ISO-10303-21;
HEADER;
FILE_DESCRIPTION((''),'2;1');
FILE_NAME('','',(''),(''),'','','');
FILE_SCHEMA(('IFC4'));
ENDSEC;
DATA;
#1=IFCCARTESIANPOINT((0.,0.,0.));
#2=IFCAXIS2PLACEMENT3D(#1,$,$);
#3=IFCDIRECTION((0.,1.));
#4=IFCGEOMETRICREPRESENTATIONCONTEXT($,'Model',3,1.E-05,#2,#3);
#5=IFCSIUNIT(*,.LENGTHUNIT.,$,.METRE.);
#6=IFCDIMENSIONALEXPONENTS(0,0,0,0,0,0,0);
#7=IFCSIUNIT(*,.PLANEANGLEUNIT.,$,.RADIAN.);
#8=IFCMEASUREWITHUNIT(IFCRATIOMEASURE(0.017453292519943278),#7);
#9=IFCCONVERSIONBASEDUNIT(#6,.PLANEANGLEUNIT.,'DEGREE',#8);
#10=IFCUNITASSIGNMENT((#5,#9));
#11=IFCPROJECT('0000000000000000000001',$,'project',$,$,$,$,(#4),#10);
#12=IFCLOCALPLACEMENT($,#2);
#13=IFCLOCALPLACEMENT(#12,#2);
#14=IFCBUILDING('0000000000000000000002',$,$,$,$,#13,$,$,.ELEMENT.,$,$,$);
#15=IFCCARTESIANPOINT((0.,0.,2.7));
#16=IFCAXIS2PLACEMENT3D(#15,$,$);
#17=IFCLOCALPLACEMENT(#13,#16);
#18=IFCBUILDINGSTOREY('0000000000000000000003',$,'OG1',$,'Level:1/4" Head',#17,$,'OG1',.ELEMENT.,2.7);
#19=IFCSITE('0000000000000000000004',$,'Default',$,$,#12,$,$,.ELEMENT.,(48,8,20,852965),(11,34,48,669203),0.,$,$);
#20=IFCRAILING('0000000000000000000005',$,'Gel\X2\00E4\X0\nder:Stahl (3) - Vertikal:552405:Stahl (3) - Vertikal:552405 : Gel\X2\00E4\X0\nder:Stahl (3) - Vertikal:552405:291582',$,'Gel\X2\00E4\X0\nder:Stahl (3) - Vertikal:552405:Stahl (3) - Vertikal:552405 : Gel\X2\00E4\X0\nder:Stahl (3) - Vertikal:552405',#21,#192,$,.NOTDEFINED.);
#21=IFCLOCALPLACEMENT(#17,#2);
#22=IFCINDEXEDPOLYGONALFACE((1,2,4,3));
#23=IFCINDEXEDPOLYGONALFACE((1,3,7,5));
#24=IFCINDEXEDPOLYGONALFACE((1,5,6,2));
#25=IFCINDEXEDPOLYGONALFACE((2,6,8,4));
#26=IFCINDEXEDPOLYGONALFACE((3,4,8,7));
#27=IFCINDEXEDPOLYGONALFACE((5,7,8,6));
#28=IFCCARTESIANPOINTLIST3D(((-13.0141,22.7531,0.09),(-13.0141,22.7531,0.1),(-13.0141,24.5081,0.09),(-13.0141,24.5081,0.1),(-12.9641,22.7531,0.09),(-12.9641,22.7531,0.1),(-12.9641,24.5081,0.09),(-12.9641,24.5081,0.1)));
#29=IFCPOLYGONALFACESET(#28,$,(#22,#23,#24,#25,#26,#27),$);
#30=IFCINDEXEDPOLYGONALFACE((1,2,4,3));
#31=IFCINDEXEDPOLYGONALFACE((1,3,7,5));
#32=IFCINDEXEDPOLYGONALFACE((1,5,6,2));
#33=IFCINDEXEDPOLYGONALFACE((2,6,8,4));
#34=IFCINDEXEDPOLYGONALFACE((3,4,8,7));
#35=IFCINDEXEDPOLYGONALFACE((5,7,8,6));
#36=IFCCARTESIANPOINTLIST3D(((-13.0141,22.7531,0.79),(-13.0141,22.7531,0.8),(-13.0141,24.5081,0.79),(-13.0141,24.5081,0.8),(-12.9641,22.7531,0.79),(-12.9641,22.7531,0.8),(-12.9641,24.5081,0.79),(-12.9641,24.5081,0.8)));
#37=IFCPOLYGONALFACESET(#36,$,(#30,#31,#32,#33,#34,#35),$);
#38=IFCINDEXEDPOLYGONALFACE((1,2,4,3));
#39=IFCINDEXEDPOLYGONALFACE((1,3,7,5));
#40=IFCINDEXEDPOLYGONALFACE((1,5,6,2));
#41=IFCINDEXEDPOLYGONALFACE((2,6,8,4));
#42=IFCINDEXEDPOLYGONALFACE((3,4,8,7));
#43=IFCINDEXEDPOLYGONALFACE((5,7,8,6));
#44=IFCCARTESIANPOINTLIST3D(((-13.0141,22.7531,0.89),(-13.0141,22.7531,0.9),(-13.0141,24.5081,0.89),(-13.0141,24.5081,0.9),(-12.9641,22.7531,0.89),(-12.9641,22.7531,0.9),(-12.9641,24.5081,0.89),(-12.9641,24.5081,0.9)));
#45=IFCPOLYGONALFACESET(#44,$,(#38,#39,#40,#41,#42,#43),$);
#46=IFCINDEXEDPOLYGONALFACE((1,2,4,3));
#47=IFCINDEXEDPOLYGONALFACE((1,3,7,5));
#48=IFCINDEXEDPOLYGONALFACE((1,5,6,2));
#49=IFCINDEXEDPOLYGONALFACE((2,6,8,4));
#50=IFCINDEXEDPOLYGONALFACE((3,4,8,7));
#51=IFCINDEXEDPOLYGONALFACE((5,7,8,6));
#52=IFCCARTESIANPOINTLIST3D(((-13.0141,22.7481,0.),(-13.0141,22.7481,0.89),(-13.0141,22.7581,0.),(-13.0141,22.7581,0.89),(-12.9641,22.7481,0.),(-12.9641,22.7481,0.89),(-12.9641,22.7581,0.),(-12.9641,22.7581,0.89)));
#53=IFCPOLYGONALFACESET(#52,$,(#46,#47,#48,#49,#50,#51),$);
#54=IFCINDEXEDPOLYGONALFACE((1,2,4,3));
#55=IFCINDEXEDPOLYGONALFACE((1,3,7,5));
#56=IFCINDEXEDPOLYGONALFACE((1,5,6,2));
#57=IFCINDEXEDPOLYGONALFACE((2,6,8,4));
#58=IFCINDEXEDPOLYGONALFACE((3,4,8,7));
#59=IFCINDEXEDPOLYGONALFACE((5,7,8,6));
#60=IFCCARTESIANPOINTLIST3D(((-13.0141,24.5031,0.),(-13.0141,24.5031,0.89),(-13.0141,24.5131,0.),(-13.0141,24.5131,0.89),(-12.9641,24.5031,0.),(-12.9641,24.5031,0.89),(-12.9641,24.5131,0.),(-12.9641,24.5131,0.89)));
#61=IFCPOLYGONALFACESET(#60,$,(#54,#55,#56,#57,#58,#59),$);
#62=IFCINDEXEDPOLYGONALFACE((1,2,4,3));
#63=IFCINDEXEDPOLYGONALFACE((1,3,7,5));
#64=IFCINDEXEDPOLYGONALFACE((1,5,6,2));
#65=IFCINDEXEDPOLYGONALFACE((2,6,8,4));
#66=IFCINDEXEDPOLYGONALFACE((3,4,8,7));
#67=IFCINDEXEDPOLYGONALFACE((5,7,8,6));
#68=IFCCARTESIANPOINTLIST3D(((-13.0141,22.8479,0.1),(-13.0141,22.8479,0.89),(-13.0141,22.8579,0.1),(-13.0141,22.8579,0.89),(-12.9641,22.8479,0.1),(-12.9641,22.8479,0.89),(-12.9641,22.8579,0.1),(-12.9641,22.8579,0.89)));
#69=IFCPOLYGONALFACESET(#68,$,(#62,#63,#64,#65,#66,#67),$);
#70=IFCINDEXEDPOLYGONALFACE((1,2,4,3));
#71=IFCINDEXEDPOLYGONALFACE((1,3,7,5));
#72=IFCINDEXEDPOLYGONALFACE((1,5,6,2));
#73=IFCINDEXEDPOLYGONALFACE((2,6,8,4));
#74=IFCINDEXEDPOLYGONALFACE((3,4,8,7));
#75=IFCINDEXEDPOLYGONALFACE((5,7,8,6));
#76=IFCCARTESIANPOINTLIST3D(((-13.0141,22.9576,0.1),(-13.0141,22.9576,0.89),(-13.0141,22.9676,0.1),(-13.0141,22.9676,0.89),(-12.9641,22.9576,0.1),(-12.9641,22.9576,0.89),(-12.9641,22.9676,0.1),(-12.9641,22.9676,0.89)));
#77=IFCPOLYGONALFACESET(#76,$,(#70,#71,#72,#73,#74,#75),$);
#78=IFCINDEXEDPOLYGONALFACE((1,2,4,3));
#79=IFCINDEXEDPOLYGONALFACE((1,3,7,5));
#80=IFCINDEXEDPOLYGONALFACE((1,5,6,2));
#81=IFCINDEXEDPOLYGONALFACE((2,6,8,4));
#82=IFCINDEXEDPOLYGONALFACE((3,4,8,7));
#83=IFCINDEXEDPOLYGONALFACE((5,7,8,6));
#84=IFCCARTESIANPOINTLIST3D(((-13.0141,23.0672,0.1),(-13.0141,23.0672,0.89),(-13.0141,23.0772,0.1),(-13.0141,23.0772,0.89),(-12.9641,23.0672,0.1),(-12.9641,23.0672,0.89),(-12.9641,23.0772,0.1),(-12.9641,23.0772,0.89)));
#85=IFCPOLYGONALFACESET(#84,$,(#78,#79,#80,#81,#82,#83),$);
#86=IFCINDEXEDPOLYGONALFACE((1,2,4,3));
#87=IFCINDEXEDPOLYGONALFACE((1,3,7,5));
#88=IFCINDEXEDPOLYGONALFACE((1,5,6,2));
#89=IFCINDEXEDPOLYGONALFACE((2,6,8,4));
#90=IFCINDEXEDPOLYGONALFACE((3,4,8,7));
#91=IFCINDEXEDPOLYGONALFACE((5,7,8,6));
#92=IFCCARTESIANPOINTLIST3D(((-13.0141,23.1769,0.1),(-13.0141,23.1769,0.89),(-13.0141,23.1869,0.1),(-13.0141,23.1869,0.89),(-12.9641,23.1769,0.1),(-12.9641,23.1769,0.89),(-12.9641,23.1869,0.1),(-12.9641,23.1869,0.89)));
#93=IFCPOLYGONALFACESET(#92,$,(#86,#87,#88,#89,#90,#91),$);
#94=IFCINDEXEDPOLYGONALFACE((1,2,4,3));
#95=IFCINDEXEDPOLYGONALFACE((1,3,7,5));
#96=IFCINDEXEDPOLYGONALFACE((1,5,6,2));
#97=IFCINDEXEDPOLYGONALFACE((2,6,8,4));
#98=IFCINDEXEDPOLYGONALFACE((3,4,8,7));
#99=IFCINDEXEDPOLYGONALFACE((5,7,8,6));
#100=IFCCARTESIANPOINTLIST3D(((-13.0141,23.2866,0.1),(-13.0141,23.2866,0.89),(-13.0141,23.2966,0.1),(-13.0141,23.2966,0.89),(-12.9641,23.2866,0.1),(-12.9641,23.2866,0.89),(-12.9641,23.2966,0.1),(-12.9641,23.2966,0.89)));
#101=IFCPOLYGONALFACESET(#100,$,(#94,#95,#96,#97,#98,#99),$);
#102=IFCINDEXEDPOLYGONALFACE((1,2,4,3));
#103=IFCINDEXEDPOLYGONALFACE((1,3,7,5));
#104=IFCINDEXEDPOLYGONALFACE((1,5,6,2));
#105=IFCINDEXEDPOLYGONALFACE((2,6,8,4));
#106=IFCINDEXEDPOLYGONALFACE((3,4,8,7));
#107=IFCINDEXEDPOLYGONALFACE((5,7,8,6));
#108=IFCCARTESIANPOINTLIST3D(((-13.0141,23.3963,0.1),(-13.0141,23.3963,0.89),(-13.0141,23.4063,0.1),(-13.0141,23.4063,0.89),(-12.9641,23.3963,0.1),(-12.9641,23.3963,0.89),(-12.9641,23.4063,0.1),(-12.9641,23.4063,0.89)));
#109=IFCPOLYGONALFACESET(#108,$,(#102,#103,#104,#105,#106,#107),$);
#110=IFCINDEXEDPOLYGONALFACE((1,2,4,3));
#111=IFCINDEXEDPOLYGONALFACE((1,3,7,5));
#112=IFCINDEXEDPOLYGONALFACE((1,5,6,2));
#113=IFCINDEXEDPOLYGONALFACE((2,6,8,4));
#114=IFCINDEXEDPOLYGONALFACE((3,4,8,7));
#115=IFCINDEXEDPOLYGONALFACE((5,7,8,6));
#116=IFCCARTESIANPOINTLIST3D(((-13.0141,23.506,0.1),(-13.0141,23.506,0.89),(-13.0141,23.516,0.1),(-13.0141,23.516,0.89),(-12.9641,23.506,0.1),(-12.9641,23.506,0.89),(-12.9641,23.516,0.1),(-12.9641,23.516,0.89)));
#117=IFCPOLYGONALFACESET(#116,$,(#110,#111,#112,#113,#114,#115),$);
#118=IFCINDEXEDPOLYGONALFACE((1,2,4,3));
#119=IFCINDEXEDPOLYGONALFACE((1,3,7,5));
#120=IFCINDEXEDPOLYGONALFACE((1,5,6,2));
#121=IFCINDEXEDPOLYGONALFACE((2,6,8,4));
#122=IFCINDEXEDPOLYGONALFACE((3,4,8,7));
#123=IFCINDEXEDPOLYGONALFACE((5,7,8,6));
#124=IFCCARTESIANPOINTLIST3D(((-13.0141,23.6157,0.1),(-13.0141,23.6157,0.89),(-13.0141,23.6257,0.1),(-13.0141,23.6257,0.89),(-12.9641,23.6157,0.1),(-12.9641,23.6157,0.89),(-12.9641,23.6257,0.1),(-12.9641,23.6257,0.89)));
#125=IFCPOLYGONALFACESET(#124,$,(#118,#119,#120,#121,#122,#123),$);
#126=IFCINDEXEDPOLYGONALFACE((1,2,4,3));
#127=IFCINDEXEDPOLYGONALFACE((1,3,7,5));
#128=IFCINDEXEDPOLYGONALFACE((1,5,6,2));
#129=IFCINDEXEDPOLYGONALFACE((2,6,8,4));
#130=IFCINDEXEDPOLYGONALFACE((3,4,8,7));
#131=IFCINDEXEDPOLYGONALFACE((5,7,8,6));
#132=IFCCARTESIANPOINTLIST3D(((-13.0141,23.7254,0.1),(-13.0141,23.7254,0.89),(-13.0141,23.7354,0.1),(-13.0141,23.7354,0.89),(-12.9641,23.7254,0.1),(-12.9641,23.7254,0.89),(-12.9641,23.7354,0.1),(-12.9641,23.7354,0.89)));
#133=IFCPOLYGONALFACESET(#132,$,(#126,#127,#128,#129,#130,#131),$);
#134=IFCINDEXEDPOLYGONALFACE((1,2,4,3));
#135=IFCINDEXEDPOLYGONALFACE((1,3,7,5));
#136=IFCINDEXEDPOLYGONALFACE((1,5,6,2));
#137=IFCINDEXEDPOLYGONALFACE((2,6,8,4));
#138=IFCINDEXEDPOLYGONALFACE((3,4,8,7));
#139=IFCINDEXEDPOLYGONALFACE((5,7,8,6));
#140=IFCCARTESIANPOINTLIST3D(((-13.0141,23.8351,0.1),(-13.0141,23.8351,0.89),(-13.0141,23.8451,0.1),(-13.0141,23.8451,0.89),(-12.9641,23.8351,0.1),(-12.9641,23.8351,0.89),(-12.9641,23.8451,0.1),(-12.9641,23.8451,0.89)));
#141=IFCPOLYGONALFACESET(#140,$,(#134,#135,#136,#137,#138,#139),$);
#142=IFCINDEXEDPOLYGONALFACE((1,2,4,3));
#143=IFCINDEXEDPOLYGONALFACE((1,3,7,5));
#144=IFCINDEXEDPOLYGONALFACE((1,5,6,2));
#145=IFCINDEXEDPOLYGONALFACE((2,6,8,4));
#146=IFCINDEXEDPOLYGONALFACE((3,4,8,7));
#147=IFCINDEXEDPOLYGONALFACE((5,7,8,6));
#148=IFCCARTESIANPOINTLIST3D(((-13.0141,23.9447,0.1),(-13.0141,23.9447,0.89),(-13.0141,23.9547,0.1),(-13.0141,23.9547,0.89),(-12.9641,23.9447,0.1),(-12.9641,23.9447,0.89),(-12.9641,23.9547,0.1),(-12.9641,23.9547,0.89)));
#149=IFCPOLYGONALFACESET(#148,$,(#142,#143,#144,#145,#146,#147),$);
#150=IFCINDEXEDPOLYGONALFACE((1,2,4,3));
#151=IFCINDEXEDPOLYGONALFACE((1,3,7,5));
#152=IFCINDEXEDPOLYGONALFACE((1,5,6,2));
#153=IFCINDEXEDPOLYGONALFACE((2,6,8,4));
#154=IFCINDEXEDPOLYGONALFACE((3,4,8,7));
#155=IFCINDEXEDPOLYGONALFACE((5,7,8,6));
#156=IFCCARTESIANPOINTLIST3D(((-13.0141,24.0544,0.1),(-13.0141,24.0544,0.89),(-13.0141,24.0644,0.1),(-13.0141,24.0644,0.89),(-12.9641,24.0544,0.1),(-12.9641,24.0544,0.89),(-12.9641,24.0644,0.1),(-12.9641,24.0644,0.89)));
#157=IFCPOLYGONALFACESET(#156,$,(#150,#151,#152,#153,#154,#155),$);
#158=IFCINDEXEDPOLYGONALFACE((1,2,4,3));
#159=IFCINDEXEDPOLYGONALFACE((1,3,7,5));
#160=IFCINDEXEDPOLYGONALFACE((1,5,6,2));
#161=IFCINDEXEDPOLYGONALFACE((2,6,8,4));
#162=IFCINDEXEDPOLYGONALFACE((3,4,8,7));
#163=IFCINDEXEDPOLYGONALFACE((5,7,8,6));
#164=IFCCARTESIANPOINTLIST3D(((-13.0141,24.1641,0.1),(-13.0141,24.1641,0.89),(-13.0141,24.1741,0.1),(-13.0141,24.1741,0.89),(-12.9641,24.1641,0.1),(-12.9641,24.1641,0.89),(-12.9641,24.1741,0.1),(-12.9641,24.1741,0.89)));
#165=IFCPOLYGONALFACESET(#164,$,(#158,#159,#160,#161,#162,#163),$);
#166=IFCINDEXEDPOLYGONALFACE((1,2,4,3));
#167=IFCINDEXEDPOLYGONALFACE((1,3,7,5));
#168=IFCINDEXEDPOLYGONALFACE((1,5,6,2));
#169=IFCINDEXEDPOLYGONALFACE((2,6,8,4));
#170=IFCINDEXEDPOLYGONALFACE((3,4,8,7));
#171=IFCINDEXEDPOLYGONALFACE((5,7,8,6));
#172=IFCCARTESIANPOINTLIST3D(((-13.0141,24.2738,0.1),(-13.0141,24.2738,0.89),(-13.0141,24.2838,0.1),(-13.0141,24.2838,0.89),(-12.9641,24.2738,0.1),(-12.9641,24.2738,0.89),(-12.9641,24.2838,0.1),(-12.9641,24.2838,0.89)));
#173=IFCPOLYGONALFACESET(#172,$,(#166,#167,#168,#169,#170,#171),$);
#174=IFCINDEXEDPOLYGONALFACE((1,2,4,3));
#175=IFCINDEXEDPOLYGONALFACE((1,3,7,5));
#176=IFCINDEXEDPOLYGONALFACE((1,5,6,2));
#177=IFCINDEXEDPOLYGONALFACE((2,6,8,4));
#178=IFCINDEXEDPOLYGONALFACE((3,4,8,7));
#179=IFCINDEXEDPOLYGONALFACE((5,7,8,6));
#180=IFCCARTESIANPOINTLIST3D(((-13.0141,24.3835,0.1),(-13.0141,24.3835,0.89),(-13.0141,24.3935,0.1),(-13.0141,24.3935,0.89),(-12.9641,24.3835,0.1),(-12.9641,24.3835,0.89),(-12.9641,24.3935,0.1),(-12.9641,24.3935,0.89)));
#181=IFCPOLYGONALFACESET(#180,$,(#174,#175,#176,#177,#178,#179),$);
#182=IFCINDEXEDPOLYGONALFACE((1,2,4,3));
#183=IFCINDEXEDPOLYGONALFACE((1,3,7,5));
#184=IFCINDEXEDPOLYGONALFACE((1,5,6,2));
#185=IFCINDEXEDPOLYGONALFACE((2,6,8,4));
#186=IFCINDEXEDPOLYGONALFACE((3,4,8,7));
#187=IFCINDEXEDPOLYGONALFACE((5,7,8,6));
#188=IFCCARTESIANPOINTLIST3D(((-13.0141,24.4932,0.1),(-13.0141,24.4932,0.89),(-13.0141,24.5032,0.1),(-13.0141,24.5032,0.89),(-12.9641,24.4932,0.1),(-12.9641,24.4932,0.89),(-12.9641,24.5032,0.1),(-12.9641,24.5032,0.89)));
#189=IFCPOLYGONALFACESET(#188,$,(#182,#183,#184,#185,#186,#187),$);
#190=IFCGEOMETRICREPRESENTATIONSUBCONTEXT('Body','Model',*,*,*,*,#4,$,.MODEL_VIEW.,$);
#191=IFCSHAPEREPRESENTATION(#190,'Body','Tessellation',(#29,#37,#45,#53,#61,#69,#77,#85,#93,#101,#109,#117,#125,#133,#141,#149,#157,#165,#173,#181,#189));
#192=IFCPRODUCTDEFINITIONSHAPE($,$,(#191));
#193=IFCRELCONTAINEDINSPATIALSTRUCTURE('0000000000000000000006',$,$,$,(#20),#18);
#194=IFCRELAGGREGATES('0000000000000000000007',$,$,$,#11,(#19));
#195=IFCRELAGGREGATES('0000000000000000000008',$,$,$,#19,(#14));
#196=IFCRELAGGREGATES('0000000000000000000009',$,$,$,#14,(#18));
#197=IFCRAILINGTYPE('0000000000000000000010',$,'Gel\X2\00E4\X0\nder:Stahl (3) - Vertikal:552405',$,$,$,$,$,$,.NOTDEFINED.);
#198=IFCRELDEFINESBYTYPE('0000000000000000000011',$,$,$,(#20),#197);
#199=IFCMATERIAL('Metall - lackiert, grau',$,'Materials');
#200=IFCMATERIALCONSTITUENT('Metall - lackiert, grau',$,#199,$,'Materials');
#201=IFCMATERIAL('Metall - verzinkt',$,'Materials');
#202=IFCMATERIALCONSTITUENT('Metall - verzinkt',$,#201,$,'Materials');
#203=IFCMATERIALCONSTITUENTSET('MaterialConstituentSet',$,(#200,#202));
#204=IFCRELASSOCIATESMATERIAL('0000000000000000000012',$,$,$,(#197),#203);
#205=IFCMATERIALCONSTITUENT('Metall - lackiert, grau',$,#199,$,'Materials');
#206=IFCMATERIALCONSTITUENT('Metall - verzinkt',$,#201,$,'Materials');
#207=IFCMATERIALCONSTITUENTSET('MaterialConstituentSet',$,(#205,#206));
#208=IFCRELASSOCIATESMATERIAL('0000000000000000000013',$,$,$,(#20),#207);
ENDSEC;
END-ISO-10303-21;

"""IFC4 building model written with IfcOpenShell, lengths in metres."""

from ifc_helpers import new_model, entity, si_unit, converted_unit, direction, frame, origin, place, context, subcontext, project, spatial, indexed_curve, outline, extrude, source, transform, mapped, material, constituent, constituent_set, type_object, type_shapes, element, save


model = new_model("IFC4")

# Units and contexts
model_context = context("Model", 3, precision=1e-05, world=origin(), true_north=direction((0.0, 1.0)))
body_context = subcontext(model_context, "Body", "Model", "MODEL_VIEW")
ifc_project = project(units=[si_unit("LENGTHUNIT", "METRE"), converted_unit("PLANEANGLEUNIT", "DEGREE", entity("IfcRatioMeasure", 0.017453292519943278), si_unit("PLANEANGLEUNIT", "RADIAN"), dimensions=[0, 0, 0, 0, 0, 0, 0])], contexts=[model_context])

# Site, building, storey
site_placement = place(None, origin())
site = spatial("IfcSite", under=ifc_project, at=site_placement, Name="Default", CompositionType="ELEMENT", RefLatitude=(48, 8, 20, 852965), RefLongitude=(11, 34, 48, 669203), RefElevation=0.0)
building_placement = place(site_placement, origin())
building = spatial("IfcBuilding", under=site, at=building_placement, CompositionType="ELEMENT")
storey_placement = place(building_placement, frame((0.0, 0.0, 2.7)))
storey = spatial("IfcBuildingStorey", under=building, at=storey_placement, Name="OG1", ObjectType="Level:1/4\" Head", LongName="OG1", CompositionType="ELEMENT", Elevation=2.7)

# Railing
ifc_material_1 = material(Name="Metall - lackiert, grau", Category="Materials")
ifc_constituent_1 = constituent(ifc_material_1, Name="Metall - lackiert, grau", Category="Materials")
ifc_material_2 = material(Name="Metall - verzinkt", Category="Materials")
ifc_constituent_2 = constituent(ifc_material_2, Name="Metall - verzinkt", Category="Materials")
ifc_constituent_set_1 = constituent_set(constituents=[ifc_constituent_1, ifc_constituent_2], Name="MaterialConstituentSet")
ifc_constituent_3 = constituent(ifc_material_1, Name="Metall - lackiert, grau", Category="Materials")
ifc_constituent_4 = constituent(ifc_material_2, Name="Metall - verzinkt", Category="Materials")
ifc_constituent_set_2 = constituent_set(constituents=[ifc_constituent_3, ifc_constituent_4], Name="MaterialConstituentSet")
railing_type_1 = type_object("IfcRailingType", Name="Geländer:Stahl (3) - Vertikal:552405", PredefinedType="NOTDEFINED", material=ifc_constituent_set_2)
shared_shape_1 = source(origin(), body_context, "Body", "SweptSolid", [
    extrude(outline(indexed_curve([(-0.025, -0.8775), (0.025, -0.8775), (0.025, 0.8775), (-0.025, 0.8775), (-0.025, -0.8775)], self_intersect=False)), frame((-12.9891, 23.6306, 2.79), z_axis=(0.0, 0.0, 1.0), x_axis=(-1.0, 0.0, 0.0)), (0.0, 0.0, 1.0), 0.01),
    extrude(outline(indexed_curve([(-0.025, -0.8775), (0.025, -0.8775), (0.025, 0.8775), (-0.025, 0.8775), (-0.025, -0.8775)], self_intersect=False)), frame((-12.9891, 23.6306, 3.49), z_axis=(0.0, 0.0, 1.0), x_axis=(-1.0, 0.0, 0.0)), (0.0, 0.0, 1.0), 0.01),
    extrude(outline(indexed_curve([(-0.025, -0.8775), (0.025, -0.8775), (0.025, 0.8775), (-0.025, 0.8775), (-0.025, -0.8775)], self_intersect=False)), frame((-12.9891, 23.6306, 3.59), z_axis=(0.0, 0.0, 1.0), x_axis=(-1.0, 0.0, 0.0)), (0.0, 0.0, 1.0), 0.01),
    extrude(outline(indexed_curve([(-0.025, -0.005), (0.025, -0.005), (0.025, 0.005), (-0.025, 0.005), (-0.025, -0.005)], self_intersect=False)), frame((-12.9891, 22.7531, 2.7), z_axis=(0.0, 0.0, 1.0), x_axis=(-1.0, 0.0, 0.0)), (0.0, 0.0, 1.0), 0.89),
    extrude(outline(indexed_curve([(-0.025, -0.005), (0.025, -0.005), (0.025, 0.005), (-0.025, 0.005), (-0.025, -0.005)], self_intersect=False)), frame((-12.9891, 24.5081, 2.7), z_axis=(0.0, 0.0, 1.0), x_axis=(-1.0, 0.0, 0.0)), (0.0, 0.0, 1.0), 0.89),
    extrude(outline(indexed_curve([(-0.025, -0.005), (0.025, -0.005), (0.025, 0.005), (-0.025, 0.005), (-0.025, -0.005)], self_intersect=False)), frame((-12.9891, 22.8529, 2.8), z_axis=(0.0, 0.0, 1.0), x_axis=(-1.0, 0.0, 0.0)), (0.0, 0.0, 1.0), 0.79),
    extrude(outline(indexed_curve([(-0.025, -0.005), (0.025, -0.005), (0.025, 0.005), (-0.025, 0.005), (-0.025, -0.005)], self_intersect=False)), frame((-12.9891, 22.9626, 2.8), z_axis=(0.0, 0.0, 1.0), x_axis=(-1.0, 0.0, 0.0)), (0.0, 0.0, 1.0), 0.79),
    extrude(outline(indexed_curve([(-0.025, -0.005), (0.025, -0.005), (0.025, 0.005), (-0.025, 0.005), (-0.025, -0.005)], self_intersect=False)), frame((-12.9891, 23.0722, 2.8), z_axis=(0.0, 0.0, 1.0), x_axis=(-1.0, 0.0, 0.0)), (0.0, 0.0, 1.0), 0.79),
    extrude(outline(indexed_curve([(-0.025, -0.005), (0.025, -0.005), (0.025, 0.005), (-0.025, 0.005), (-0.025, -0.005)], self_intersect=False)), frame((-12.9891, 23.1819, 2.8), z_axis=(0.0, 0.0, 1.0), x_axis=(-1.0, 0.0, 0.0)), (0.0, 0.0, 1.0), 0.79),
    extrude(outline(indexed_curve([(-0.025, -0.005), (0.025, -0.005), (0.025, 0.005), (-0.025, 0.005), (-0.025, -0.005)], self_intersect=False)), frame((-12.9891, 23.2916, 2.8), z_axis=(0.0, 0.0, 1.0), x_axis=(-1.0, 0.0, 0.0)), (0.0, 0.0, 1.0), 0.79),
    extrude(outline(indexed_curve([(-0.025, -0.005), (0.025, -0.005), (0.025, 0.005), (-0.025, 0.005), (-0.025, -0.005)], self_intersect=False)), frame((-12.9891, 23.4013, 2.8), z_axis=(0.0, 0.0, 1.0), x_axis=(-1.0, 0.0, 0.0)), (0.0, 0.0, 1.0), 0.79),
    extrude(outline(indexed_curve([(-0.025, -0.005), (0.025, -0.005), (0.025, 0.005), (-0.025, 0.005), (-0.025, -0.005)], self_intersect=False)), frame((-12.9891, 23.511, 2.8), z_axis=(0.0, 0.0, 1.0), x_axis=(-1.0, 0.0, 0.0)), (0.0, 0.0, 1.0), 0.79),
    extrude(outline(indexed_curve([(-0.025, -0.005), (0.025, -0.005), (0.025, 0.005), (-0.025, 0.005), (-0.025, -0.005)], self_intersect=False)), frame((-12.9891, 23.6207, 2.8), z_axis=(0.0, 0.0, 1.0), x_axis=(-1.0, 0.0, 0.0)), (0.0, 0.0, 1.0), 0.79),
    extrude(outline(indexed_curve([(-0.025, -0.005), (0.025, -0.005), (0.025, 0.005), (-0.025, 0.005), (-0.025, -0.005)], self_intersect=False)), frame((-12.9891, 23.7304, 2.8), z_axis=(0.0, 0.0, 1.0), x_axis=(-1.0, 0.0, 0.0)), (0.0, 0.0, 1.0), 0.79),
    extrude(outline(indexed_curve([(-0.025, -0.005), (0.025, -0.005), (0.025, 0.005), (-0.025, 0.005), (-0.025, -0.005)], self_intersect=False)), frame((-12.9891, 23.8401, 2.8), z_axis=(0.0, 0.0, 1.0), x_axis=(-1.0, 0.0, 0.0)), (0.0, 0.0, 1.0), 0.79),
    extrude(outline(indexed_curve([(-0.025, -0.005), (0.025, -0.005), (0.025, 0.005), (-0.025, 0.005), (-0.025, -0.005)], self_intersect=False)), frame((-12.9891, 23.9497, 2.8), z_axis=(0.0, 0.0, 1.0), x_axis=(-1.0, 0.0, 0.0)), (0.0, 0.0, 1.0), 0.79),
    extrude(outline(indexed_curve([(-0.025, -0.005), (0.025, -0.005), (0.025, 0.005), (-0.025, 0.005), (-0.025, -0.005)], self_intersect=False)), frame((-12.9891, 24.0594, 2.8), z_axis=(0.0, 0.0, 1.0), x_axis=(-1.0, 0.0, 0.0)), (0.0, 0.0, 1.0), 0.79),
    extrude(outline(indexed_curve([(-0.025, -0.005), (0.025, -0.005), (0.025, 0.005), (-0.025, 0.005), (-0.025, -0.005)], self_intersect=False)), frame((-12.9891, 24.1691, 2.8), z_axis=(0.0, 0.0, 1.0), x_axis=(-1.0, 0.0, 0.0)), (0.0, 0.0, 1.0), 0.79),
    extrude(outline(indexed_curve([(-0.025, -0.005), (0.025, -0.005), (0.025, 0.005), (-0.025, 0.005), (-0.025, -0.005)], self_intersect=False)), frame((-12.9891, 24.2788, 2.8), z_axis=(0.0, 0.0, 1.0), x_axis=(-1.0, 0.0, 0.0)), (0.0, 0.0, 1.0), 0.79),
    extrude(outline(indexed_curve([(-0.025, -0.005), (0.025, -0.005), (0.025, 0.005), (-0.025, 0.005), (-0.025, -0.005)], self_intersect=False)), frame((-12.9891, 24.3885, 2.8), z_axis=(0.0, 0.0, 1.0), x_axis=(-1.0, 0.0, 0.0)), (0.0, 0.0, 1.0), 0.79),
    extrude(outline(indexed_curve([(-0.025, -0.005), (0.025, -0.005), (0.025, 0.005), (-0.025, 0.005), (-0.025, -0.005)], self_intersect=False)), frame((-12.9891, 24.4982, 2.8), z_axis=(0.0, 0.0, 1.0), x_axis=(-1.0, 0.0, 0.0)), (0.0, 0.0, 1.0), 0.79),
])
type_shapes(railing_type_1, [shared_shape_1])
railing_1_placement = place(storey_placement, frame((0.0, 0.0, -2.7)))
element("IfcRailing", 1, at=railing_1_placement, inside=storey, type_object=railing_type_1, material=ifc_constituent_set_1, Name="Geländer:Stahl (3) - Vertikal:552405:Stahl (3) - Vertikal:552405 : Geländer:Stahl (3) - Vertikal:552405:291582", ObjectType="Geländer:Stahl (3) - Vertikal:552405:Stahl (3) - Vertikal:552405 : Geländer:Stahl (3) - Vertikal:552405", PredefinedType="NOTDEFINED", context=body_context, shape_type="MappedRepresentation", body=[
    mapped(shared_shape_1, transform((0.0, 0.0, 0.0), scale=1.0)),
])

save(model, "model.ifc")
